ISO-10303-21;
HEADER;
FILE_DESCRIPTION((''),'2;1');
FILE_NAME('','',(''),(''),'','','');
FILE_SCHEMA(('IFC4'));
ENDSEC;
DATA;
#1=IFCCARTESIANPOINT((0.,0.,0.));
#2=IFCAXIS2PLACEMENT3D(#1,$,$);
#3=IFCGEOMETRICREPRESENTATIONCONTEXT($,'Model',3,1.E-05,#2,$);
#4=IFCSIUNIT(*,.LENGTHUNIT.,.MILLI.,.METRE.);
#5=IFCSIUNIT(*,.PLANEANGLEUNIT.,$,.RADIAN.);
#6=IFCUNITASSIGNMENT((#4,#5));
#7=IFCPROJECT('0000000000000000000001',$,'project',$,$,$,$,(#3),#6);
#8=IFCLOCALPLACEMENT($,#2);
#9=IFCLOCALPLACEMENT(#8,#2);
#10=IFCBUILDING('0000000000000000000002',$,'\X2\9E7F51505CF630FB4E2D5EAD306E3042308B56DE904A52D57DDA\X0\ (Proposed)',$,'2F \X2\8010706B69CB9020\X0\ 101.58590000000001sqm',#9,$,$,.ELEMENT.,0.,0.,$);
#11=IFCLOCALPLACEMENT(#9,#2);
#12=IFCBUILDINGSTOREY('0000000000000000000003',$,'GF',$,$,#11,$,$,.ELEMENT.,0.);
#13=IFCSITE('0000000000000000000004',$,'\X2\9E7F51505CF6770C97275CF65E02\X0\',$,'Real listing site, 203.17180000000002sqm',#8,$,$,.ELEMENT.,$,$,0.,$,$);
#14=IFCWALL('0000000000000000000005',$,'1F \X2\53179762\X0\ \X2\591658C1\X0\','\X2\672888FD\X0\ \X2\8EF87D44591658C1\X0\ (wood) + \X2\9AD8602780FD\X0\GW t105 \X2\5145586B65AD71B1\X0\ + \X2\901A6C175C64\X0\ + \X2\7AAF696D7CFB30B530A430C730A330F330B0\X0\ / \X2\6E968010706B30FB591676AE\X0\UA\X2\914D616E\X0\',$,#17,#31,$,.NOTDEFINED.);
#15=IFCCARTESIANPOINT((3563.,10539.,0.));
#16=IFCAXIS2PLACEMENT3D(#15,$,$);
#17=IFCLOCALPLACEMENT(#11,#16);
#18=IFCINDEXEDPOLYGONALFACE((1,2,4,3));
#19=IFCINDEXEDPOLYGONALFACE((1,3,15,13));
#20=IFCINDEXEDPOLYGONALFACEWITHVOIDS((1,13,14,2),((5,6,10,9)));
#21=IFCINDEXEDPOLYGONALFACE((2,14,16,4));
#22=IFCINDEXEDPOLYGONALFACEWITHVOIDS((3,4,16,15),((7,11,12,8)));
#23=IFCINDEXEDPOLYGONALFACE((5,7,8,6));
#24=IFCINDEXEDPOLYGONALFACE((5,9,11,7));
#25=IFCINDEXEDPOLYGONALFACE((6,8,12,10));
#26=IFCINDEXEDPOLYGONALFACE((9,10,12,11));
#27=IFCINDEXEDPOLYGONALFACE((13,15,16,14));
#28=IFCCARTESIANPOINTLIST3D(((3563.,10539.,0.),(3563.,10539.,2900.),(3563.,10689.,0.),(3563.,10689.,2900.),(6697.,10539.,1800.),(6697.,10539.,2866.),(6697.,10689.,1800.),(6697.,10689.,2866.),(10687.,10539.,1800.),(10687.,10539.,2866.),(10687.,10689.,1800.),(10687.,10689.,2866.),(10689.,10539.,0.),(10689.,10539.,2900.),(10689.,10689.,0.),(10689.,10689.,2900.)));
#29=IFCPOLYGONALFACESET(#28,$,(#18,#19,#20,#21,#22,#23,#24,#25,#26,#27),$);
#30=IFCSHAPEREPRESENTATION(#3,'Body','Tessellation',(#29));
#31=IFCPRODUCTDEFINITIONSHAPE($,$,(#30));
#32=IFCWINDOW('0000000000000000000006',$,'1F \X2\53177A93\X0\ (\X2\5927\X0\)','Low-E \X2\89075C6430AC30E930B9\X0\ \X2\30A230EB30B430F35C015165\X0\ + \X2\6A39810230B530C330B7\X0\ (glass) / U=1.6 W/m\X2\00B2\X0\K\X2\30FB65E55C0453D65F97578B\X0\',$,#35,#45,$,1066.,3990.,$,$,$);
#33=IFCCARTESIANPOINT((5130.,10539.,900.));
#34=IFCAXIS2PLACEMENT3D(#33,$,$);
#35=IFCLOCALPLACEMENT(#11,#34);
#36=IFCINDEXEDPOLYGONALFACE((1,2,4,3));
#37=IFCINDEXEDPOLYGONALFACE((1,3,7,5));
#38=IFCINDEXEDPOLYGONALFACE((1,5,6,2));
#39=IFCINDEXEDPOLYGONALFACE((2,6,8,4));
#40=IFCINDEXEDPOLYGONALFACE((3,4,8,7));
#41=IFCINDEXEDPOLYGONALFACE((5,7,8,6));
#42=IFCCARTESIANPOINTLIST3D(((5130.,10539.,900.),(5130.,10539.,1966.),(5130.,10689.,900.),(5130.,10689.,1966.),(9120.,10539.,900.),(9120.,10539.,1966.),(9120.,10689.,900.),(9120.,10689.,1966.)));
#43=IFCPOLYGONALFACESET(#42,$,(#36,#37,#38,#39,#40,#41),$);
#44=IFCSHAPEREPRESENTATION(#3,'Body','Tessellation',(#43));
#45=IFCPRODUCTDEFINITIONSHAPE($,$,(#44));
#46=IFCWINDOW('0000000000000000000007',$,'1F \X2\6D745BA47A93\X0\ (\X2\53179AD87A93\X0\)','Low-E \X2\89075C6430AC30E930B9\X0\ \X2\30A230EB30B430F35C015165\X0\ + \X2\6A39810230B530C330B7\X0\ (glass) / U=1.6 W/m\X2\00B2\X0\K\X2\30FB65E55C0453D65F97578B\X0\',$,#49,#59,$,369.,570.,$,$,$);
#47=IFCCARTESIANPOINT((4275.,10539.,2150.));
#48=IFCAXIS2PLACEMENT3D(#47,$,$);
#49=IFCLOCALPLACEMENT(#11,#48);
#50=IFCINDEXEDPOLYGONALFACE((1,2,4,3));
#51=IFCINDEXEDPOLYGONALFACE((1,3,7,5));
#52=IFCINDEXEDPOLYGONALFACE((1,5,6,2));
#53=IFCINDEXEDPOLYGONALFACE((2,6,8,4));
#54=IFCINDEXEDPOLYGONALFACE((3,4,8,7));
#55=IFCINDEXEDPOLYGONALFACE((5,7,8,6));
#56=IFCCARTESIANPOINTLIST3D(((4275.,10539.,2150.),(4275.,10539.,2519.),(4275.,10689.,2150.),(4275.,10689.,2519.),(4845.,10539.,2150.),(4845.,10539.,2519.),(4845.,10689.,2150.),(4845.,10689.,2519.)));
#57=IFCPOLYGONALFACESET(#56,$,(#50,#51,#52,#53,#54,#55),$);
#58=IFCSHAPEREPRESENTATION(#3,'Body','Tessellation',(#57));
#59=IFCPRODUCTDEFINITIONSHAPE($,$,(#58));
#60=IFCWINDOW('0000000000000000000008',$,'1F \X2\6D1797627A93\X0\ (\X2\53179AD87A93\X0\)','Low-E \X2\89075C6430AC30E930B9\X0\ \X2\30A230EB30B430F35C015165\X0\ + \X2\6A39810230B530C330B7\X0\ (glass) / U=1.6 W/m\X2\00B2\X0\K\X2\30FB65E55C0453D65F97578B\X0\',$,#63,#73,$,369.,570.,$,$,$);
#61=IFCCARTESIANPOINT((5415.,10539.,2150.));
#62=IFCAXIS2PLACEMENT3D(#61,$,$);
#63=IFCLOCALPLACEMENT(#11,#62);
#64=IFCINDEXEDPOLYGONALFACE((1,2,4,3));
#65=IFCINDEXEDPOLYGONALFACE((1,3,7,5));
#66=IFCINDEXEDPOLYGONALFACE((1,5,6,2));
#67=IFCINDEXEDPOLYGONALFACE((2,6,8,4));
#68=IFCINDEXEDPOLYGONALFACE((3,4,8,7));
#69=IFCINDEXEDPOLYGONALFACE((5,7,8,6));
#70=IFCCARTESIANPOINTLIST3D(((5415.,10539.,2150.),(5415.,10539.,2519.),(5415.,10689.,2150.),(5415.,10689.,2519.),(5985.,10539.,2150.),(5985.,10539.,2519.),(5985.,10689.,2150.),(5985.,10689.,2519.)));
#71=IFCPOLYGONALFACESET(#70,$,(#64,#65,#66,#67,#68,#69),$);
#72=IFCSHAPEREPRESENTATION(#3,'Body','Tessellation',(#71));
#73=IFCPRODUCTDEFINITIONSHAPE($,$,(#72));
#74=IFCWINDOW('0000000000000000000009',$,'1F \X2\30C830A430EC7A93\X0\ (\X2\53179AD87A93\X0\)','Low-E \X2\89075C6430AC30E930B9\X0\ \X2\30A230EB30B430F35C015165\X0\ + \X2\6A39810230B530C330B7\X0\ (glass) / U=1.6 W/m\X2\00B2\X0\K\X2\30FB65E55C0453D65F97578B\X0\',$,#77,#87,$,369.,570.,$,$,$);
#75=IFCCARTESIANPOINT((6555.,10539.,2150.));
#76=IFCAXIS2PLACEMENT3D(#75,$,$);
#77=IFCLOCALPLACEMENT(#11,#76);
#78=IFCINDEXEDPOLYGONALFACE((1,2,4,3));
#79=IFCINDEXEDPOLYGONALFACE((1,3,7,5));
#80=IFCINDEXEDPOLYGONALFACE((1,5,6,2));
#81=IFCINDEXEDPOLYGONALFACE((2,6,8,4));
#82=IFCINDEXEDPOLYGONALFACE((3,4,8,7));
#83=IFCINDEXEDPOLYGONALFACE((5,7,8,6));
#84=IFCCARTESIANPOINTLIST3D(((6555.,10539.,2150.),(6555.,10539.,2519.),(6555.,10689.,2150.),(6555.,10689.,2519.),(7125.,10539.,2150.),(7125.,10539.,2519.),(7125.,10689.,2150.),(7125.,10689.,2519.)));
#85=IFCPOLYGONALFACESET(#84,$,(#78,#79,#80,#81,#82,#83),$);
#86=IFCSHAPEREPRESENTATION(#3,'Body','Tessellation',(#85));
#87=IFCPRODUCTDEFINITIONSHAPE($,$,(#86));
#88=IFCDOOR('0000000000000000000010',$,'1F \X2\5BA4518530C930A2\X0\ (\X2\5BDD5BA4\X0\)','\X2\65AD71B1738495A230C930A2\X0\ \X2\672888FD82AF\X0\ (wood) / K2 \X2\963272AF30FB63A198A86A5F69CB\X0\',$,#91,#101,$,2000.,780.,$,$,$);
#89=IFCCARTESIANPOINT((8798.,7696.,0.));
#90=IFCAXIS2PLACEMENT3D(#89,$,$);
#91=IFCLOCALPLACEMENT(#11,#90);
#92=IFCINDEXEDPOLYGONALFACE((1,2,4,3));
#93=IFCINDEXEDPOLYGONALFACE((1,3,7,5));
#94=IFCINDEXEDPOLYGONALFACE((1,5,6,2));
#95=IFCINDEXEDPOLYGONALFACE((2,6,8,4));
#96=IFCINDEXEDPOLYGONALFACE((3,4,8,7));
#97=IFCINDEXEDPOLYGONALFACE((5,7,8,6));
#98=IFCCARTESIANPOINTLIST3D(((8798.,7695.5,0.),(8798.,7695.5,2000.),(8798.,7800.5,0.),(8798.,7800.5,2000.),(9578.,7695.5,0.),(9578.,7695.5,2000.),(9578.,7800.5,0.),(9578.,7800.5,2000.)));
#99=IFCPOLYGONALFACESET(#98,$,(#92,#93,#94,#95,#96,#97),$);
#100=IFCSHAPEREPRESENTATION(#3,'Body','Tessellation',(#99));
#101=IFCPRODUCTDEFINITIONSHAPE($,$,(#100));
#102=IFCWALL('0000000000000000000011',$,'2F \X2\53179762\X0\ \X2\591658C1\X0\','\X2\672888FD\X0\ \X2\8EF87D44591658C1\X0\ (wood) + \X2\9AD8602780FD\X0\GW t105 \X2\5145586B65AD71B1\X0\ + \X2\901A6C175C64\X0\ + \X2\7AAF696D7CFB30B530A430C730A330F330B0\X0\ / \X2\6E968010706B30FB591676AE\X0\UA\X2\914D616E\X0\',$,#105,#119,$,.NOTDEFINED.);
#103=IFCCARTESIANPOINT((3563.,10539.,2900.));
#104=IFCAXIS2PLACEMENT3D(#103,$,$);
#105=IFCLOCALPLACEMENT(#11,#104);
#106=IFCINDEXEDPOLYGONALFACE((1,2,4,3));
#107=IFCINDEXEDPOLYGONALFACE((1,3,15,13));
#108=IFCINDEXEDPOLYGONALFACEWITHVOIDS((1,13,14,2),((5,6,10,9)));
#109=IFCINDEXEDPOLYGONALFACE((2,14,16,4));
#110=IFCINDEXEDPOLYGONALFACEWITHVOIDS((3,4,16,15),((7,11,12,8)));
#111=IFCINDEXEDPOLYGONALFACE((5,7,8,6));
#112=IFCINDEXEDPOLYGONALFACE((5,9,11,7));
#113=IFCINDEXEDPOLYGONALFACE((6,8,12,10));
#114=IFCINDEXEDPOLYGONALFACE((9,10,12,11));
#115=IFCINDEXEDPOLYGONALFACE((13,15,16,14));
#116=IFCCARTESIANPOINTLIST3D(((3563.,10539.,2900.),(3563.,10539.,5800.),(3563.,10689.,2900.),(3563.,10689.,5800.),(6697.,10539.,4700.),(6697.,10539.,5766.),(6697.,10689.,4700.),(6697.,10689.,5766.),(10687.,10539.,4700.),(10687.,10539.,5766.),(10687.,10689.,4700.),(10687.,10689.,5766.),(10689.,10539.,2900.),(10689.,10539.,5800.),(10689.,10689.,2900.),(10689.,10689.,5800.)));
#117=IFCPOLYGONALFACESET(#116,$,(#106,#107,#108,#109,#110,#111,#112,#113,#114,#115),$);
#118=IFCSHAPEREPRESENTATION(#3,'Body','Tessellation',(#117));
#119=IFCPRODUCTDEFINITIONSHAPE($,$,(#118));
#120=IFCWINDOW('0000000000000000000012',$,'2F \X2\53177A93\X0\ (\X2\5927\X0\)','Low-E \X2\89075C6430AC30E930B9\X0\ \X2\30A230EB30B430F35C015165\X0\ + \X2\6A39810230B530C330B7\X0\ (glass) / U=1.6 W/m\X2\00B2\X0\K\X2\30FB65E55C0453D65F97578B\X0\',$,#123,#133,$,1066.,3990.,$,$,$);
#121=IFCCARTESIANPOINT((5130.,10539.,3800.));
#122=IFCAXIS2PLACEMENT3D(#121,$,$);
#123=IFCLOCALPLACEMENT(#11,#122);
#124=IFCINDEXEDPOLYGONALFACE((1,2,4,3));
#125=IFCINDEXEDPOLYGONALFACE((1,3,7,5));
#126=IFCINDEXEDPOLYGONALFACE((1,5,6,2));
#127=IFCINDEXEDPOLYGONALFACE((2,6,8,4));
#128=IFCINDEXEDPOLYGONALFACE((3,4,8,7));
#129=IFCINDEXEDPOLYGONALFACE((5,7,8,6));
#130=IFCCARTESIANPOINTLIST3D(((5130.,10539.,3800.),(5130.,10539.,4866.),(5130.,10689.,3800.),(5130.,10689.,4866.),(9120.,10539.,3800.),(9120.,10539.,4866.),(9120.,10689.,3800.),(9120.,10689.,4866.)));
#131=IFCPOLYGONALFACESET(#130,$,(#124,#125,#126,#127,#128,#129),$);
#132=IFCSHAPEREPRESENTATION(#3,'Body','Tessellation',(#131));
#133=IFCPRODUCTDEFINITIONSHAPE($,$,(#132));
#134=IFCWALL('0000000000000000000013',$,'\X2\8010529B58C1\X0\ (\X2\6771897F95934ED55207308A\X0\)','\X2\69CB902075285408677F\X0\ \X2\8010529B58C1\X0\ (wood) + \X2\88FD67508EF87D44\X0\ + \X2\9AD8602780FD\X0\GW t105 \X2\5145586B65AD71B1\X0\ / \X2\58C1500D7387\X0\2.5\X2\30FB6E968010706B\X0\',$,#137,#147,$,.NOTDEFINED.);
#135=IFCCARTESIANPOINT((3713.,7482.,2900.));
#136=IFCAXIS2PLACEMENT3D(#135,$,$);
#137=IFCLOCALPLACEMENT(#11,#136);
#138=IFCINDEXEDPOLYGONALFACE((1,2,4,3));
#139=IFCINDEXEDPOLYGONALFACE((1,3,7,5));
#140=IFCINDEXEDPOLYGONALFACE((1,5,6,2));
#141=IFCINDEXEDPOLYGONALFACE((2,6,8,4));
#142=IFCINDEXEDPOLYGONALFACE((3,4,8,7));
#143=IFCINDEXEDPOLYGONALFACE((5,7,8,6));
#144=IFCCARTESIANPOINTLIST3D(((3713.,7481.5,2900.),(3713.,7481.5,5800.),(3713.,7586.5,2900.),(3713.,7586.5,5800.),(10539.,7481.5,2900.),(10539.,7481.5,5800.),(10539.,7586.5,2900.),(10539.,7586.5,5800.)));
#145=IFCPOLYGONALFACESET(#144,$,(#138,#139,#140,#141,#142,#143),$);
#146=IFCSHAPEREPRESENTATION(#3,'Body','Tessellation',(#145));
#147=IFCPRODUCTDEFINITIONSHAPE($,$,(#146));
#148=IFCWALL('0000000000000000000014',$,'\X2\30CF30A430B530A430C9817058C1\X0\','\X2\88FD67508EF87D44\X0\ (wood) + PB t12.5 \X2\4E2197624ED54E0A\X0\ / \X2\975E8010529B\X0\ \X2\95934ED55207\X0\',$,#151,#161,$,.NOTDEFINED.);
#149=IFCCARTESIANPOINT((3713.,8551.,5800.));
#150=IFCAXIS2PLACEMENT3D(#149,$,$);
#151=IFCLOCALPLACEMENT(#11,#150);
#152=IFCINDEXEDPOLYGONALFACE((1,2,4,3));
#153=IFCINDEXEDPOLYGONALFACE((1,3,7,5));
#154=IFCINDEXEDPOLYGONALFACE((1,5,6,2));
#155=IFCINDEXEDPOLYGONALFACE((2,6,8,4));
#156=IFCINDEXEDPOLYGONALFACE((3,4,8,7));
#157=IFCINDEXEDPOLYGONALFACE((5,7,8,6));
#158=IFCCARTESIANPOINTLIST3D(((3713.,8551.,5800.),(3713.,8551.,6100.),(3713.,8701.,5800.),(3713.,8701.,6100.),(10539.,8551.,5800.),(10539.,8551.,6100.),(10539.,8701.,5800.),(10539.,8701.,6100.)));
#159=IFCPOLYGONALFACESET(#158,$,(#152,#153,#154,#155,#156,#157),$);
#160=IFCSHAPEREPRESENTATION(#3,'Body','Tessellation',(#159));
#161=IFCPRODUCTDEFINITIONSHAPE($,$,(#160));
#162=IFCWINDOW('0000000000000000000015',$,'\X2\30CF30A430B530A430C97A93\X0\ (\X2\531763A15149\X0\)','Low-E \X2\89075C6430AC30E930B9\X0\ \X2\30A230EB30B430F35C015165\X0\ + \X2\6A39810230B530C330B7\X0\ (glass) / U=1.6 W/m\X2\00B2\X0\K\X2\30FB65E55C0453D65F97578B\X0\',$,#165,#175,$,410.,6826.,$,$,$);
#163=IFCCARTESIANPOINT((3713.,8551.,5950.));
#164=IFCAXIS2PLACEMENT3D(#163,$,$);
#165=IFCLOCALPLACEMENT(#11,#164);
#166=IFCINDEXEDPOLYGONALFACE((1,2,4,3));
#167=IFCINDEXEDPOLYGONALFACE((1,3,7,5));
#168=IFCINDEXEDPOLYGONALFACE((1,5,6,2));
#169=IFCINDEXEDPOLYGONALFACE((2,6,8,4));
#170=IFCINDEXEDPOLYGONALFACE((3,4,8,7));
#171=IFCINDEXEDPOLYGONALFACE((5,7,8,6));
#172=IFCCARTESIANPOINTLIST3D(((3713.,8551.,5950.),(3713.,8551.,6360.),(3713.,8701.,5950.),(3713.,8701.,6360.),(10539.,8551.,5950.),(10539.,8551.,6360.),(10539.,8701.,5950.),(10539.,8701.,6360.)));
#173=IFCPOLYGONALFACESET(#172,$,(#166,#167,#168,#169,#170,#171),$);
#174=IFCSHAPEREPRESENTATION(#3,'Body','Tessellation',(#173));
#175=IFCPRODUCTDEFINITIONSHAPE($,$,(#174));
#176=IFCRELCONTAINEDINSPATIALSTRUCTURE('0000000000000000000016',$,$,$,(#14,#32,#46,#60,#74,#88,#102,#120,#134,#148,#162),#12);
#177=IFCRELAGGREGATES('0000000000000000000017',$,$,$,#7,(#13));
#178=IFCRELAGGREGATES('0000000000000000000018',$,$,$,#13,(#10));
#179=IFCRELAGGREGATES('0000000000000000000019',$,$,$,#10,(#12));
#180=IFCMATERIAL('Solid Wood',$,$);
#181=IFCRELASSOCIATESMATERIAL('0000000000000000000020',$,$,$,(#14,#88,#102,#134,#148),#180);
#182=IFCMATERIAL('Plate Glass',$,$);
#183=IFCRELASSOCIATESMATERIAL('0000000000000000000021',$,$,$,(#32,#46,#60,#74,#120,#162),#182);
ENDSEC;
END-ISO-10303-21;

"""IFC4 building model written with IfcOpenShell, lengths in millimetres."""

from ifc_helpers import new_model, si_unit, frame, frame_2d, origin, place, context, project, spatial, rectangle, extrude, material, element, fill, save


model = new_model("IFC4")

# Units and contexts
model_context = context("Model", 3, precision=1e-05, world=origin())
ifc_project = project(units=[si_unit("LENGTHUNIT", "METRE", prefix="MILLI"), si_unit("PLANEANGLEUNIT", "RADIAN")], contexts=[model_context])

# Site, building, storey
site_placement = place(None, origin())
site = spatial("IfcSite", under=ifc_project, at=site_placement, Name="鹿児島県霧島市", ObjectType="Real listing site, 203.17180000000002sqm", CompositionType="ELEMENT", RefElevation=0.0)
building_placement = place(site_placement, origin())
building = spatial("IfcBuilding", under=site, at=building_placement, Name="鹿児島・中庭のある回遊動線 (Proposed)", ObjectType="2F 耐火構造 101.58590000000001sqm", CompositionType="ELEMENT", ElevationOfRefHeight=0.0, ElevationOfTerrain=0.0)
storey_placement = place(building_placement, origin())
storey = spatial("IfcBuildingStorey", under=building, at=storey_placement, Name="GF", CompositionType="ELEMENT", Elevation=0.0)

# Wall, openings, windows
ifc_material_1 = material(Name="Solid Wood")
wall_1_placement = place(storey_placement, frame((3563.0, 10539.0, 0.0)))
wall_1 = element("IfcWall", 1, at=wall_1_placement, inside=storey, material=ifc_material_1, Name="1F 北面 外壁", Description="木製 軸組外壁 (wood) + 高性能GW t105 充填断熱 + 通気層 + 窯業系サイディング / 準耐火・外皮UA配慮", PredefinedType="NOTDEFINED", context=model_context, shape_type="SweptSolid", body=[
    extrude(rectangle(XDim=7126.0, YDim=150.0, at=frame_2d((3563.0, 75.0))), frame((3563.0, 10539.0, 0.0)), (0.0, 0.0, 1.0), 2900.0),
])
opening_1_placement = place(storey_placement, frame((5130.0, 10539.0, 900.0)))
opening_1 = element("IfcOpeningElement", 2, at=opening_1_placement, cuts=wall_1, PredefinedType="NOTDEFINED", context=model_context, shape_type="SweptSolid", body=[
    extrude(rectangle(XDim=3990.0, YDim=150.0, at=frame_2d((1995.0, 75.0))), frame((5130.0, 10539.0, 900.0)), (0.0, 0.0, 1.0), 1066.0),
])
opening_2_placement = place(storey_placement, frame((4275.0, 10539.0, 2150.0)))
opening_2 = element("IfcOpeningElement", 3, at=opening_2_placement, cuts=wall_1, PredefinedType="NOTDEFINED", context=model_context, shape_type="SweptSolid", body=[
    extrude(rectangle(XDim=570.0, YDim=150.0, at=frame_2d((285.0, 75.0))), frame((4275.0, 10539.0, 2150.0)), (0.0, 0.0, 1.0), 369.0),
])
opening_3_placement = place(storey_placement, frame((5415.0, 10539.0, 2150.0)))
opening_3 = element("IfcOpeningElement", 4, at=opening_3_placement, cuts=wall_1, PredefinedType="NOTDEFINED", context=model_context, shape_type="SweptSolid", body=[
    extrude(rectangle(XDim=570.0, YDim=150.0, at=frame_2d((285.0, 75.0))), frame((5415.0, 10539.0, 2150.0)), (0.0, 0.0, 1.0), 369.0),
])
opening_4_placement = place(storey_placement, frame((6555.0, 10539.0, 2150.0)))
opening_4 = element("IfcOpeningElement", 5, at=opening_4_placement, cuts=wall_1, PredefinedType="NOTDEFINED", context=model_context, shape_type="SweptSolid", body=[
    extrude(rectangle(XDim=570.0, YDim=150.0, at=frame_2d((285.0, 75.0))), frame((6555.0, 10539.0, 2150.0)), (0.0, 0.0, 1.0), 369.0),
])
ifc_material_2 = material(Name="Plate Glass")
window_1_placement = place(storey_placement, frame((5130.0, 10539.0, 900.0)))
window_1 = element("IfcWindow", 6, at=window_1_placement, inside=storey, material=ifc_material_2, Name="1F 北窓 (大)", Description="Low-E 複層ガラス アルゴン封入 + 樹脂サッシ (glass) / U=1.6 W/m²K・日射取得型", OverallHeight=1066.0, OverallWidth=3990.0, context=model_context, shape_type="SweptSolid", body=[
    extrude(rectangle(XDim=3990.0, YDim=150.0, at=frame_2d((1995.0, 75.0))), frame((5130.0, 10539.0, 900.0)), (0.0, 0.0, 1.0), 1066.0),
])
fill(opening_1, window_1)
window_2_placement = place(storey_placement, frame((4275.0, 10539.0, 2150.0)))
window_2 = element("IfcWindow", 7, at=window_2_placement, inside=storey, material=ifc_material_2, Name="1F 浴室窓 (北高窓)", Description="Low-E 複層ガラス アルゴン封入 + 樹脂サッシ (glass) / U=1.6 W/m²K・日射取得型", OverallHeight=369.0, OverallWidth=570.0, context=model_context, shape_type="SweptSolid", body=[
    extrude(rectangle(XDim=570.0, YDim=150.0, at=frame_2d((285.0, 75.0))), frame((4275.0, 10539.0, 2150.0)), (0.0, 0.0, 1.0), 369.0),
])
fill(opening_2, window_2)
window_3_placement = place(storey_placement, frame((5415.0, 10539.0, 2150.0)))
window_3 = element("IfcWindow", 8, at=window_3_placement, inside=storey, material=ifc_material_2, Name="1F 洗面窓 (北高窓)", Description="Low-E 複層ガラス アルゴン封入 + 樹脂サッシ (glass) / U=1.6 W/m²K・日射取得型", OverallHeight=369.0, OverallWidth=570.0, context=model_context, shape_type="SweptSolid", body=[
    extrude(rectangle(XDim=570.0, YDim=150.0, at=frame_2d((285.0, 75.0))), frame((5415.0, 10539.0, 2150.0)), (0.0, 0.0, 1.0), 369.0),
])
fill(opening_3, window_3)
window_4_placement = place(storey_placement, frame((6555.0, 10539.0, 2150.0)))
window_4 = element("IfcWindow", 9, at=window_4_placement, inside=storey, material=ifc_material_2, Name="1F トイレ窓 (北高窓)", Description="Low-E 複層ガラス アルゴン封入 + 樹脂サッシ (glass) / U=1.6 W/m²K・日射取得型", OverallHeight=369.0, OverallWidth=570.0, context=model_context, shape_type="SweptSolid", body=[
    extrude(rectangle(XDim=570.0, YDim=150.0, at=frame_2d((285.0, 75.0))), frame((6555.0, 10539.0, 2150.0)), (0.0, 0.0, 1.0), 369.0),
])
fill(opening_4, window_4)

# Door
door_1_placement = place(storey_placement, frame((8798.0, 7696.0, 0.0)))
element("IfcDoor", 10, at=door_1_placement, inside=storey, material=ifc_material_1, Name="1F 室内ドア (寝室)", Description="断熱玄関ドア 木製芯 (wood) / K2 防犯・採風機構", OverallHeight=2000.0, OverallWidth=780.0, context=model_context, shape_type="SweptSolid", body=[
    extrude(rectangle(XDim=780.0, YDim=105.0, at=frame_2d((390.0, 52.0))), frame((8798.0, 7696.0, 0.0)), (0.0, 0.0, 1.0), 2000.0),
])

# Wall, opening, window
wall_2_placement = place(storey_placement, frame((3563.0, 10539.0, 2900.0)))
wall_2 = element("IfcWall", 11, at=wall_2_placement, inside=storey, material=ifc_material_1, Name="2F 北面 外壁", Description="木製 軸組外壁 (wood) + 高性能GW t105 充填断熱 + 通気層 + 窯業系サイディング / 準耐火・外皮UA配慮", PredefinedType="NOTDEFINED", context=model_context, shape_type="SweptSolid", body=[
    extrude(rectangle(XDim=7126.0, YDim=150.0, at=frame_2d((3563.0, 75.0))), frame((3563.0, 10539.0, 2900.0)), (0.0, 0.0, 1.0), 2900.0),
])
opening_5_placement = place(storey_placement, frame((5130.0, 10539.0, 3800.0)))
opening_5 = element("IfcOpeningElement", 12, at=opening_5_placement, cuts=wall_2, PredefinedType="NOTDEFINED", context=model_context, shape_type="SweptSolid", body=[
    extrude(rectangle(XDim=3990.0, YDim=150.0, at=frame_2d((1995.0, 75.0))), frame((5130.0, 10539.0, 3800.0)), (0.0, 0.0, 1.0), 1066.0),
])
window_5_placement = place(storey_placement, frame((5130.0, 10539.0, 3800.0)))
window_5 = element("IfcWindow", 13, at=window_5_placement, inside=storey, material=ifc_material_2, Name="2F 北窓 (大)", Description="Low-E 複層ガラス アルゴン封入 + 樹脂サッシ (glass) / U=1.6 W/m²K・日射取得型", OverallHeight=1066.0, OverallWidth=3990.0, context=model_context, shape_type="SweptSolid", body=[
    extrude(rectangle(XDim=3990.0, YDim=150.0, at=frame_2d((1995.0, 75.0))), frame((5130.0, 10539.0, 3800.0)), (0.0, 0.0, 1.0), 1066.0),
])
fill(opening_5, window_5)

# Wall
wall_3_placement = place(storey_placement, frame((3713.0, 7482.0, 2900.0)))
element("IfcWall", 14, at=wall_3_placement, inside=storey, material=ifc_material_1, Name="耐力壁 (東西間仕切り)", Description="構造用合板 耐力壁 (wood) + 製材軸組 + 高性能GW t105 充填断熱 / 壁倍率2.5・準耐火", PredefinedType="NOTDEFINED", context=model_context, shape_type="SweptSolid", body=[
    extrude(rectangle(XDim=6826.0, YDim=105.0, at=frame_2d((3413.0, 52.0))), frame((3713.0, 7482.0, 2900.0)), (0.0, 0.0, 1.0), 2900.0),
])

# Wall, opening, window
wall_4_placement = place(storey_placement, frame((3713.0, 8551.0, 5800.0)))
wall_4 = element("IfcWall", 15, at=wall_4_placement, inside=storey, material=ifc_material_1, Name="ハイサイド腰壁", Description="製材軸組 (wood) + PB t12.5 両面仕上 / 非耐力 間仕切", PredefinedType="NOTDEFINED", context=model_context, shape_type="SweptSolid", body=[
    extrude(rectangle(XDim=6826.0, YDim=150.0, at=frame_2d((3413.0, 75.0))), frame((3713.0, 8551.0, 5800.0)), (0.0, 0.0, 1.0), 700.0),
])
opening_6_placement = place(storey_placement, frame((3713.0, 8551.0, 5950.0)))
opening_6 = element("IfcOpeningElement", 16, at=opening_6_placement, cuts=wall_4, PredefinedType="NOTDEFINED", context=model_context, shape_type="SweptSolid", body=[
    extrude(rectangle(XDim=6826.0, YDim=150.0, at=frame_2d((3413.0, 75.0))), frame((3713.0, 8551.0, 5950.0)), (0.0, 0.0, 1.0), 410.0),
])
window_6_placement = place(storey_placement, frame((3713.0, 8551.0, 5950.0)))
window_6 = element("IfcWindow", 17, at=window_6_placement, inside=storey, material=ifc_material_2, Name="ハイサイド窓 (北採光)", Description="Low-E 複層ガラス アルゴン封入 + 樹脂サッシ (glass) / U=1.6 W/m²K・日射取得型", OverallHeight=410.0, OverallWidth=6826.0, context=model_context, shape_type="SweptSolid", body=[
    extrude(rectangle(XDim=6826.0, YDim=150.0, at=frame_2d((3413.0, 75.0))), frame((3713.0, 8551.0, 5950.0)), (0.0, 0.0, 1.0), 410.0),
])
fill(opening_6, window_6)

save(model, "model.ifc")
